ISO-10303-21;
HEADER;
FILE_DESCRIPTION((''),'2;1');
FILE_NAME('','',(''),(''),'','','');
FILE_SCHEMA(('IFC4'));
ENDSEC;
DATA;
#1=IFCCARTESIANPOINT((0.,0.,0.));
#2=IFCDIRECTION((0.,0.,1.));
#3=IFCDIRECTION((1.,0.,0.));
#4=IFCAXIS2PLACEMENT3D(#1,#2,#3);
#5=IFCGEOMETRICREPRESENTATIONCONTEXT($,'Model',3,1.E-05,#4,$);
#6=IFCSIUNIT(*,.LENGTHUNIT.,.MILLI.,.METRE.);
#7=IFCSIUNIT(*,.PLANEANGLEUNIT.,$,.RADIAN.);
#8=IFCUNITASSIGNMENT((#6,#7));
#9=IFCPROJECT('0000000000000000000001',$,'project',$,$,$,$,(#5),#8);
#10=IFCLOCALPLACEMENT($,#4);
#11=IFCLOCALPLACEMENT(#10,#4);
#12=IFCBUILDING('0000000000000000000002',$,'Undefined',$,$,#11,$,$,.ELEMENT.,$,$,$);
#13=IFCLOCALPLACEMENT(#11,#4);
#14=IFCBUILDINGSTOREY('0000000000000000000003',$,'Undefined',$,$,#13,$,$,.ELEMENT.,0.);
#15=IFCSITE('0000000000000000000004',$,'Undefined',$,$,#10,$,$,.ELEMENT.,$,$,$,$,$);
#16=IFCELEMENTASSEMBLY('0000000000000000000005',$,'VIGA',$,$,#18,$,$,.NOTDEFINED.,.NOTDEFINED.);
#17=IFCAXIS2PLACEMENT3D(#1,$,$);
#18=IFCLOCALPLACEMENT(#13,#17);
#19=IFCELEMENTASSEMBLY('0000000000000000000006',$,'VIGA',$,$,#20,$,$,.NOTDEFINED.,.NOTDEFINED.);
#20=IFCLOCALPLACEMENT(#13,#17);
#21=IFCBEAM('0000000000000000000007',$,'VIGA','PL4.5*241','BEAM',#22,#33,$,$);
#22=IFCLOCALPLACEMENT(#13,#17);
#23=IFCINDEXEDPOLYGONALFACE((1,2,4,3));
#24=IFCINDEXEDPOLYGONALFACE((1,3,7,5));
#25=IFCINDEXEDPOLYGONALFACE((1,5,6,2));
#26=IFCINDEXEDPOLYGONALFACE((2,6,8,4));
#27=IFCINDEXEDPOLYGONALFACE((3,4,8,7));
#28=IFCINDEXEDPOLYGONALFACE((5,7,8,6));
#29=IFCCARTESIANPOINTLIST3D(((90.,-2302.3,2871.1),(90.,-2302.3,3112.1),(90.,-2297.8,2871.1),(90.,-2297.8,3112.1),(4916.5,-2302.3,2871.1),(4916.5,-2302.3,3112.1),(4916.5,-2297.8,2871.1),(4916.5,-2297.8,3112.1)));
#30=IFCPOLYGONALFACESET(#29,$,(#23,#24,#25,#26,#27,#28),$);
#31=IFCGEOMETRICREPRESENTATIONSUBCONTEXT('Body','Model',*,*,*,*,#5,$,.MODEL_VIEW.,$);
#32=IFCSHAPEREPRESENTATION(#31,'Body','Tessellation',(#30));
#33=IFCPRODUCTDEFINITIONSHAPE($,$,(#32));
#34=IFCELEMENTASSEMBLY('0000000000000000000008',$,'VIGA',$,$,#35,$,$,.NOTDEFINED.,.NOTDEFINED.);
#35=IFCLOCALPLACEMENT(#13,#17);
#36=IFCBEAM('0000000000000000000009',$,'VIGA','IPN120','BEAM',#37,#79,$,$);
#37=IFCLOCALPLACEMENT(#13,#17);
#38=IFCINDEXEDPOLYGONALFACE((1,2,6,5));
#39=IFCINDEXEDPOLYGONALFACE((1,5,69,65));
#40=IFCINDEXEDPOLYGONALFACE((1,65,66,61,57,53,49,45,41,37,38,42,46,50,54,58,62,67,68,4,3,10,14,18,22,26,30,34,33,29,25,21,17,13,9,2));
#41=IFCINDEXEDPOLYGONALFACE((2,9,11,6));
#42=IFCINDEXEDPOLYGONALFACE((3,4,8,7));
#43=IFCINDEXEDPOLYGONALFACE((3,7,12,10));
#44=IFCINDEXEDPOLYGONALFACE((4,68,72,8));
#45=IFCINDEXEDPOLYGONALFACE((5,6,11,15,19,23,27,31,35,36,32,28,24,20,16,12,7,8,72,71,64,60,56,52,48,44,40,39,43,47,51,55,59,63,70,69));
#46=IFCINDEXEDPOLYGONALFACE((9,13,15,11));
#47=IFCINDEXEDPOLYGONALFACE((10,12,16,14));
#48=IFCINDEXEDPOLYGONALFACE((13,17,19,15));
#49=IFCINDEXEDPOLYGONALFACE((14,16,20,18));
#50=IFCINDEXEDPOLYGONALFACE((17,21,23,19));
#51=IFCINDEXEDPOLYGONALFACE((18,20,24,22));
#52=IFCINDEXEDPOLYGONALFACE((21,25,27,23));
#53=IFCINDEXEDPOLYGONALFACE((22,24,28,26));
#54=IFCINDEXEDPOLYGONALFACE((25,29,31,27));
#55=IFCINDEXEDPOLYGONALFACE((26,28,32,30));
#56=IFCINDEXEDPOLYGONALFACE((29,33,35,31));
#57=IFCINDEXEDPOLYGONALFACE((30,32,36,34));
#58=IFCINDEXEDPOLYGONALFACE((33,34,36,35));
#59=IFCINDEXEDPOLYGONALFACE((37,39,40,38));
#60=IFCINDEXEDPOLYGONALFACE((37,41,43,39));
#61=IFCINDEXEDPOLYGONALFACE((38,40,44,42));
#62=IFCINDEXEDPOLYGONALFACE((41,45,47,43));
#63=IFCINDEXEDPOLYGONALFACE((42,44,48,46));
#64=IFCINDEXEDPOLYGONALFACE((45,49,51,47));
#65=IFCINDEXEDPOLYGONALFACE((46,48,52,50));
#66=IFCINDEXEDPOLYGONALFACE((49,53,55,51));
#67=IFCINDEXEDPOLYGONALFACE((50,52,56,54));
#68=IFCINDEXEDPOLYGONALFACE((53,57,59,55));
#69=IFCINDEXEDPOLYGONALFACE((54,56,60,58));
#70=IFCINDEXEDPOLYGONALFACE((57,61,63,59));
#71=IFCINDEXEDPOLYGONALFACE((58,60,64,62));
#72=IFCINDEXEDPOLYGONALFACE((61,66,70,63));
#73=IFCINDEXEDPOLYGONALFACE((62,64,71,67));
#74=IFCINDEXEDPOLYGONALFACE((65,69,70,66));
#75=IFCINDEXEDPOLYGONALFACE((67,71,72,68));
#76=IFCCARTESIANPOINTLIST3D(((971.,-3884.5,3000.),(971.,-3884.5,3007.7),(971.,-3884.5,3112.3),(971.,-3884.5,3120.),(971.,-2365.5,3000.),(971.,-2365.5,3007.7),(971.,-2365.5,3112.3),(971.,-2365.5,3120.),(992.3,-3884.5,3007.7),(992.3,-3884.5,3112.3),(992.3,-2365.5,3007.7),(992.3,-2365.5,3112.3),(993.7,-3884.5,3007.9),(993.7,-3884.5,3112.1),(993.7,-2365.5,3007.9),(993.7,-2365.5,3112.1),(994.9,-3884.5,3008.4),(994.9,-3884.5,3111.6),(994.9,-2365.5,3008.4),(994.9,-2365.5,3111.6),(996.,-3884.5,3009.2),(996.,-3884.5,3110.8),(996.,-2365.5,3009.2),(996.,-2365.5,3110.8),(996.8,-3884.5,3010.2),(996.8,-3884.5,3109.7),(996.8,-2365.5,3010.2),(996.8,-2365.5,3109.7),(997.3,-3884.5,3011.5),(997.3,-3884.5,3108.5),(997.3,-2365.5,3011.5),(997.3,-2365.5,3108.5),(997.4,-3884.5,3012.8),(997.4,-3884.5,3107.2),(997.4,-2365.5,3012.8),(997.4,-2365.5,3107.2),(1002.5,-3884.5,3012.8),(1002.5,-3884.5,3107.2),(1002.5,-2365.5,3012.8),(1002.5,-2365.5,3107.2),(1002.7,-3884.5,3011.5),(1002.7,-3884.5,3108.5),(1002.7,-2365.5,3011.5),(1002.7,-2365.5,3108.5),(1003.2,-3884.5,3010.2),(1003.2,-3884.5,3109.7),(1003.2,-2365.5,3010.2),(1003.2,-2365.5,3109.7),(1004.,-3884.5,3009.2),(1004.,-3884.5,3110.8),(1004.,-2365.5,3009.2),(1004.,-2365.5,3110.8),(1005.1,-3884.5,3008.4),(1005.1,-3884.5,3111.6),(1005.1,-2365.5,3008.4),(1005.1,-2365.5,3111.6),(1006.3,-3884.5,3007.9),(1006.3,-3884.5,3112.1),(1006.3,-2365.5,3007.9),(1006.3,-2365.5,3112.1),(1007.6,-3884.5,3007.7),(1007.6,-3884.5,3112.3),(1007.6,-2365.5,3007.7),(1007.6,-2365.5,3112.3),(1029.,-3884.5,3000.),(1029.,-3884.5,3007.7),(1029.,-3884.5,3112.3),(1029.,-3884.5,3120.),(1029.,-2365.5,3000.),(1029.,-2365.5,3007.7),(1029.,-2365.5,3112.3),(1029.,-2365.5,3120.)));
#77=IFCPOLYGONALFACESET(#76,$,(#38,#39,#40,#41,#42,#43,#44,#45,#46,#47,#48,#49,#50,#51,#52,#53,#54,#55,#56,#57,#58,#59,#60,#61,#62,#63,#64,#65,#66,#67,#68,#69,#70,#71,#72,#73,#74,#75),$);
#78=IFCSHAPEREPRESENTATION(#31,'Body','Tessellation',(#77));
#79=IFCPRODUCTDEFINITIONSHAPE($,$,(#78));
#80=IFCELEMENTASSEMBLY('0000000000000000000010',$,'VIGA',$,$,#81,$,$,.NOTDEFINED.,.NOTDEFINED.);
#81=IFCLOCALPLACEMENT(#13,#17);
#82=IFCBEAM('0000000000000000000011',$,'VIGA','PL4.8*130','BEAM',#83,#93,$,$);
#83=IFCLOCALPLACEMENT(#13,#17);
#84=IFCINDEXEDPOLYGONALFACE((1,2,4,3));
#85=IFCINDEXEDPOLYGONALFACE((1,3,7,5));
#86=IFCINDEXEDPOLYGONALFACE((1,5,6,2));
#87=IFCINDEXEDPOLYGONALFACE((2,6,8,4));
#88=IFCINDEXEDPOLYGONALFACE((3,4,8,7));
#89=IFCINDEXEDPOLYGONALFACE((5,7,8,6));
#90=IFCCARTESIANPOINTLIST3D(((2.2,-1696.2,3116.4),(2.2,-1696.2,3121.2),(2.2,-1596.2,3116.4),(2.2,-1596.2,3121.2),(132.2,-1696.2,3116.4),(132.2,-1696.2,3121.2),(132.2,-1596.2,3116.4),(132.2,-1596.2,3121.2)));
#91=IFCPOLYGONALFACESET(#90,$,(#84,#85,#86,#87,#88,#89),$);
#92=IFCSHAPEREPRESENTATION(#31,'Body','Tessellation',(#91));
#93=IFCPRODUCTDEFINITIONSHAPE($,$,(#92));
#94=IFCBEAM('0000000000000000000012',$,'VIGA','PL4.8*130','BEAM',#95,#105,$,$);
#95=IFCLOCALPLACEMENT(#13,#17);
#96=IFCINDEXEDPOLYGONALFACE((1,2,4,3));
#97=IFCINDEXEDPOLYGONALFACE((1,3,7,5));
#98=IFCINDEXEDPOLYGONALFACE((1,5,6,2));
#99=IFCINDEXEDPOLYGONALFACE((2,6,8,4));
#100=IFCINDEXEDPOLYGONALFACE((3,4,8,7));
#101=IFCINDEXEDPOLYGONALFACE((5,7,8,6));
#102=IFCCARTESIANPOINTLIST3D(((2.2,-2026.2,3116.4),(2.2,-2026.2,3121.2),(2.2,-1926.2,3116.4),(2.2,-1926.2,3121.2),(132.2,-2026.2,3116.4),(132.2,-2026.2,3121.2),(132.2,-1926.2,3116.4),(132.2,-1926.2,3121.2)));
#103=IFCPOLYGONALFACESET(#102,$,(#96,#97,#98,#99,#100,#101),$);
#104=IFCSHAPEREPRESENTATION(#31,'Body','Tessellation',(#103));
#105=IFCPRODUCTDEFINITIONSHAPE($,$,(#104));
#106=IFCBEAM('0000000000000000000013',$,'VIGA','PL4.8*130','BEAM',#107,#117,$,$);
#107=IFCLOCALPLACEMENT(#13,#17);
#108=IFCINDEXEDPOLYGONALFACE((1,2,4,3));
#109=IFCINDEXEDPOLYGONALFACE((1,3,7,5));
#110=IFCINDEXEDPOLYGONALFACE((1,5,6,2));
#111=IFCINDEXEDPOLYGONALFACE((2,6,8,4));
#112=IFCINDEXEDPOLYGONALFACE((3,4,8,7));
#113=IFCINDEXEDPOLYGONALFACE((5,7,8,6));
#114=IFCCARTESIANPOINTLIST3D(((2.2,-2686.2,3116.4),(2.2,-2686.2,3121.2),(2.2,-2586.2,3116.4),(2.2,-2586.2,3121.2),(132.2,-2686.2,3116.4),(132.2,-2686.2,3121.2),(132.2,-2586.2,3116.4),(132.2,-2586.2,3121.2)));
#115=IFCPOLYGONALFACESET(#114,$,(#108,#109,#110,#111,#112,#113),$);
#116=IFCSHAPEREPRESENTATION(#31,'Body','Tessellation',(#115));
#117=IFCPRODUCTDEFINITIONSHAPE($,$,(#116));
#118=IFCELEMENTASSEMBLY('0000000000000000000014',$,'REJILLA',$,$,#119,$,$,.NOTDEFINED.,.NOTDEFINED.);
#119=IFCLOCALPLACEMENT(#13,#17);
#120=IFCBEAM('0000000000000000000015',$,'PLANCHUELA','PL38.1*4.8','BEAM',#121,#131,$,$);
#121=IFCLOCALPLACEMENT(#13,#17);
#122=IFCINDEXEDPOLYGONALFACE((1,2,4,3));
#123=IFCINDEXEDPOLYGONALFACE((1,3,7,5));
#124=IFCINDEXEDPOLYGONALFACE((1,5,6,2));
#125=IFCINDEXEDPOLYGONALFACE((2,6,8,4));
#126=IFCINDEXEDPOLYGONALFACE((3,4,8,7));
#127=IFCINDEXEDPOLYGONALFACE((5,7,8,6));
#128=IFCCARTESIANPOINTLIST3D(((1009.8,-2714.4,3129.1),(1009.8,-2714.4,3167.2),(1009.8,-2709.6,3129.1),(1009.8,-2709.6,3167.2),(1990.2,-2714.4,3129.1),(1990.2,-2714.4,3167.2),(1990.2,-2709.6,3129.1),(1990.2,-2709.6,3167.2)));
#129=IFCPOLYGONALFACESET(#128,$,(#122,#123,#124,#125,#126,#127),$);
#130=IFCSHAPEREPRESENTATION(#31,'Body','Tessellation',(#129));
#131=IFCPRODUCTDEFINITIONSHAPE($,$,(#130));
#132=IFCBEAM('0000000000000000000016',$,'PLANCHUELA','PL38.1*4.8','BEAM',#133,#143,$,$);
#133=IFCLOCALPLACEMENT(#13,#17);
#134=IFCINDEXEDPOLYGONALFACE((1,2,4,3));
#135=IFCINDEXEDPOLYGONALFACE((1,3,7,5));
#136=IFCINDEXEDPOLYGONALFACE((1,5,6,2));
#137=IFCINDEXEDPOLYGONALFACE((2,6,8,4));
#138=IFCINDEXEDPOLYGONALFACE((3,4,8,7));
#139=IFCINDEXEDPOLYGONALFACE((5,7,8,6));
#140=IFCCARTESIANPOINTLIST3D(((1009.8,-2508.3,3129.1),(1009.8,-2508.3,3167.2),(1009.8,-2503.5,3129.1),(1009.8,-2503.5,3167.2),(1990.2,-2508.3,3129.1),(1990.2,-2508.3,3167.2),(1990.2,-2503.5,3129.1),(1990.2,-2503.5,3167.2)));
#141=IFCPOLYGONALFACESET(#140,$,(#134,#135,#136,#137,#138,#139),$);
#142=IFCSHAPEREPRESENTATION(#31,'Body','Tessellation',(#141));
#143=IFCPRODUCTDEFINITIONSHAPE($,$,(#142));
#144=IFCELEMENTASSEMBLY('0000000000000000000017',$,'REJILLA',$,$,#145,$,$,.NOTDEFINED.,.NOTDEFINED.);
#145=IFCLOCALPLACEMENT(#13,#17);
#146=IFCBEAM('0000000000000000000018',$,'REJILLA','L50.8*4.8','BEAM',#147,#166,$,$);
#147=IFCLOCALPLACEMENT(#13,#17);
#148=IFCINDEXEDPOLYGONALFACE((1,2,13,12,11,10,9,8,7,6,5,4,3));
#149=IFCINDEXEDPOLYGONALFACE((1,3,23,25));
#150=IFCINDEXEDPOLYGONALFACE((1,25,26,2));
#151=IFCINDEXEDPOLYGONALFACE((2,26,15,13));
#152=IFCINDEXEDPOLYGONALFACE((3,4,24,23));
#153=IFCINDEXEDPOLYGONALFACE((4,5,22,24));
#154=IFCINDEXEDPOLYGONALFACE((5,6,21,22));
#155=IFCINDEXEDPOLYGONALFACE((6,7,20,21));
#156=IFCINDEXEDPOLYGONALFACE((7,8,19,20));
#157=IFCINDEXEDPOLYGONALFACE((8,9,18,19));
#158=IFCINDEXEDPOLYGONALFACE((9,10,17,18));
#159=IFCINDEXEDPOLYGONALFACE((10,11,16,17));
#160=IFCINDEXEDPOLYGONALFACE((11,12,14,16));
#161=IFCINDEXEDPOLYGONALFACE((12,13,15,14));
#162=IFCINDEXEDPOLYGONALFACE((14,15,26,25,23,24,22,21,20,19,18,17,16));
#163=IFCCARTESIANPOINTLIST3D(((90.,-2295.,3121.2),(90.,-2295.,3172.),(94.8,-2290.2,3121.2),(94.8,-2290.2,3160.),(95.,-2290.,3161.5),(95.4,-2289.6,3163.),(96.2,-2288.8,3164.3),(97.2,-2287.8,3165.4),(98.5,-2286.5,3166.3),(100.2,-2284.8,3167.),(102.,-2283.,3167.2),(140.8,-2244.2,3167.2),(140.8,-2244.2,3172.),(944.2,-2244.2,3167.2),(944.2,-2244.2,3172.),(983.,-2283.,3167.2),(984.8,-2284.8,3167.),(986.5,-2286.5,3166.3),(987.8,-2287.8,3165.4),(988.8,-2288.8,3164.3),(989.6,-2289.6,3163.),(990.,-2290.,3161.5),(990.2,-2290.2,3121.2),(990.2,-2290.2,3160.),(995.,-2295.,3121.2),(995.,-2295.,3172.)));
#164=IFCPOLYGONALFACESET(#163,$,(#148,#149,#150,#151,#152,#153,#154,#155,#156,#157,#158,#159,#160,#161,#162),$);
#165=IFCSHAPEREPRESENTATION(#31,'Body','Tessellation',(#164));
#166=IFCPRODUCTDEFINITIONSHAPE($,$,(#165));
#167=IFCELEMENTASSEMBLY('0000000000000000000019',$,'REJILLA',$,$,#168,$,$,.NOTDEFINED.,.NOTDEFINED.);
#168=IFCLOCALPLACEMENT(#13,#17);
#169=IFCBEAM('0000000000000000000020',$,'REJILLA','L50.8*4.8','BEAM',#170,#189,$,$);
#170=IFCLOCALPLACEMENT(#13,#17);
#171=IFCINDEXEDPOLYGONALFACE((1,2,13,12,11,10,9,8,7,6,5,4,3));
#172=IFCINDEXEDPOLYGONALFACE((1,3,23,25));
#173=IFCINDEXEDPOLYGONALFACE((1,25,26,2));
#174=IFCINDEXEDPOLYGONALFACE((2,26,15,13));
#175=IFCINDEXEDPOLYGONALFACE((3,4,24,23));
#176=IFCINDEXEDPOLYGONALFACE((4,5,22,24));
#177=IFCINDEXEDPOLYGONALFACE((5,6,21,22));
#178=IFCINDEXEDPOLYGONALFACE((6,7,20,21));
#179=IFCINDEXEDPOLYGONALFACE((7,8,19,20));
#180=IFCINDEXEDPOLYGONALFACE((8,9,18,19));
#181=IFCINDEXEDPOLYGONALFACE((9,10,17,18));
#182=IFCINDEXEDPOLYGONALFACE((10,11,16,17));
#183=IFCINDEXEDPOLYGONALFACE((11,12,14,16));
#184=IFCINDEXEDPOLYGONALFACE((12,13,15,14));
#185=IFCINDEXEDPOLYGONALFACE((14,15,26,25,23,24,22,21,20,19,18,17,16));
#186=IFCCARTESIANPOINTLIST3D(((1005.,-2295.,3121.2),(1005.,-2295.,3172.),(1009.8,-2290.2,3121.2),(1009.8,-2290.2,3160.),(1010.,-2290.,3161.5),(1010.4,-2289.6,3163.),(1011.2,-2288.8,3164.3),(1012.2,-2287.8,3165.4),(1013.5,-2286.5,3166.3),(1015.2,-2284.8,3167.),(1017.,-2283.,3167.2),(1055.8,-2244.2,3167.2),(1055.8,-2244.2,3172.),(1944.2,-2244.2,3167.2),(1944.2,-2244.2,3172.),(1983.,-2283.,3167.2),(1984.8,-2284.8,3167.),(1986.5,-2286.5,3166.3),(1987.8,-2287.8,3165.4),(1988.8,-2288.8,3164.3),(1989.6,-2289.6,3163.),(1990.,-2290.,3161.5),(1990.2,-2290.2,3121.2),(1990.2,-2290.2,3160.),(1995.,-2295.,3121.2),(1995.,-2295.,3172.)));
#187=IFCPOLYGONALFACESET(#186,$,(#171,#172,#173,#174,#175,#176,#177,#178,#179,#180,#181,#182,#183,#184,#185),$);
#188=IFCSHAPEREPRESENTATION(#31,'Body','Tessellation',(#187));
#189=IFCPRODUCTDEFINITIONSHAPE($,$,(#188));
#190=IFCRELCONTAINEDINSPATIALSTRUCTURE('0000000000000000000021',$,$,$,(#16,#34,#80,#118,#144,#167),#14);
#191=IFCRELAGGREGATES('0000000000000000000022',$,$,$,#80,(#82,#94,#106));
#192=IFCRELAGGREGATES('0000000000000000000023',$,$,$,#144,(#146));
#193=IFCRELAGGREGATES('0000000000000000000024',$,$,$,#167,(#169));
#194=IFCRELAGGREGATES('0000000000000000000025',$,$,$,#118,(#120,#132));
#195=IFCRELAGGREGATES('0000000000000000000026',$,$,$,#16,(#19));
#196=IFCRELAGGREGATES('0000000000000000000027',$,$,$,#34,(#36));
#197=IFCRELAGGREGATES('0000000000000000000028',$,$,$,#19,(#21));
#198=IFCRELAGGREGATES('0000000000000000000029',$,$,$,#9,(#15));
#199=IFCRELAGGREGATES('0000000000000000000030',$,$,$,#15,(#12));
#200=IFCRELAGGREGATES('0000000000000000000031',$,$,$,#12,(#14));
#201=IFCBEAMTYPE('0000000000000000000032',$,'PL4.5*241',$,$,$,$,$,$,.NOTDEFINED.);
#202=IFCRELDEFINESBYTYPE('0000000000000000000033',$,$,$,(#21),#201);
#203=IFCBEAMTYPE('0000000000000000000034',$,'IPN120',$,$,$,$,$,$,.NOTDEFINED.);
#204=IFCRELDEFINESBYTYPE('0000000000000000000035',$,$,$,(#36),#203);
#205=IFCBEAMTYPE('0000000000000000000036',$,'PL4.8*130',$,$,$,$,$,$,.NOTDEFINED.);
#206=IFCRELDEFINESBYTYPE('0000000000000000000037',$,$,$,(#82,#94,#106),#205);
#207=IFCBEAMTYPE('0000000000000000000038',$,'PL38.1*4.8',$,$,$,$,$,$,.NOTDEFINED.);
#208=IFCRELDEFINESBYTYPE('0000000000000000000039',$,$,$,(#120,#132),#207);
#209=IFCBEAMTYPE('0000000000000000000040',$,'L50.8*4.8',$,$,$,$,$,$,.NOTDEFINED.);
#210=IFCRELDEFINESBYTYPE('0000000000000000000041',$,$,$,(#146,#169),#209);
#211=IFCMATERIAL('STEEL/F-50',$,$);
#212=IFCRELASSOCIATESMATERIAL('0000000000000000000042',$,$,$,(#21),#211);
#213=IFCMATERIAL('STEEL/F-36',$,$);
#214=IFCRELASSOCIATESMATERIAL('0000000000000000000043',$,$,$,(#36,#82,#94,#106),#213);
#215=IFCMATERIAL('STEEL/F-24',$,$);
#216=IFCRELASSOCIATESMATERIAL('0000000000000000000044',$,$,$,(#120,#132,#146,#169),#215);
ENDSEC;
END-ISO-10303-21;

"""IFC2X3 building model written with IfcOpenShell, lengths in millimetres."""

from ifc_helpers import new_model, si_unit, frame, origin_with_axes, origin_2d_with_axis, place, context, subcontext, project, spatial, rectangle, i_section, l_section, extrude, clip, halfspace, material, type_object, element, aggregate, save


model = new_model("IFC2X3")

# Units and contexts
model_context = context("Model", 3, precision=1e-05, world=origin_with_axes())
body_context = subcontext(model_context, "Body", "Model", "MODEL_VIEW")
ifc_project = project(units=[si_unit("LENGTHUNIT", "METRE", prefix="MILLI"), si_unit("PLANEANGLEUNIT", "RADIAN")], contexts=[model_context])

# Site, building, storey
site_placement = place(None, origin_with_axes())
site = spatial("IfcSite", under=ifc_project, at=site_placement, Name="Undefined", CompositionType="ELEMENT")
building_placement = place(site_placement, origin_with_axes())
building = spatial("IfcBuilding", under=site, at=building_placement, Name="Undefined", CompositionType="ELEMENT")
storey_placement = place(building_placement, origin_with_axes())
storey = spatial("IfcBuildingStorey", under=building, at=storey_placement, Name="Undefined", CompositionType="ELEMENT", Elevation=0.0)

# Element assemblies, beam
assembly_1_placement = place(storey_placement, origin_with_axes())
assembly_1 = element("IfcElementAssembly", 1, at=assembly_1_placement, inside=storey, Name="VIGA", AssemblyPlace="NOTDEFINED", PredefinedType="NOTDEFINED")
assembly_2_placement = place(assembly_1_placement, origin_with_axes())
assembly_2 = element("IfcElementAssembly", 2, at=assembly_2_placement, Name="VIGA", AssemblyPlace="NOTDEFINED", PredefinedType="NOTDEFINED")
ifc_material_1 = material(Name="STEEL/F-50")
beam_type_1 = type_object("IfcBeamType", Name="PL4.5*241", PredefinedType="NOTDEFINED")
beam_1_placement = place(assembly_2_placement, frame((90.0, -2300.0, 2991.6), z_axis=(0.0, 0.0, 1.0), x_axis=(1.0, 0.0, 0.0)))
beam_1 = element("IfcBeam", 3, at=beam_1_placement, type_object=beam_type_1, material=ifc_material_1, Name="VIGA", Description="PL4.5*241", ObjectType="BEAM", context=body_context, shape_type="SweptSolid", body=[
    extrude(rectangle(XDim=4.5, YDim=241.0, at=origin_2d_with_axis()), frame((4826.5, 0.0, 0.0), z_axis=(-1.0, 0.0, 0.0), x_axis=(0.0, -1.0, 0.0)), (0.0, 0.0, 1.0), 4826.5),
])

# Element assembly, beam
assembly_3_placement = place(storey_placement, origin_with_axes())
assembly_3 = element("IfcElementAssembly", 4, at=assembly_3_placement, inside=storey, Name="VIGA", AssemblyPlace="NOTDEFINED", PredefinedType="NOTDEFINED")
ifc_material_2 = material(Name="STEEL/F-36")
beam_type_2 = type_object("IfcBeamType", Name="IPN120", PredefinedType="NOTDEFINED")
beam_2_placement = place(assembly_3_placement, frame((1000.0, -2365.5, 3060.0), z_axis=(0.0, 0.0, 1.0), x_axis=(0.0, -1.0, 0.0)))
beam_2 = element("IfcBeam", 5, at=beam_2_placement, type_object=beam_type_2, material=ifc_material_2, Name="VIGA", Description="IPN120", ObjectType="BEAM", context=body_context, shape_type="SweptSolid", body=[
    extrude(i_section(OverallWidth=58.0, OverallDepth=120.0, WebThickness=5.1, FlangeThickness=7.7, FilletRadius=5.1, at=origin_2d_with_axis()), frame((1519.0, 0.0, 0.0), z_axis=(-1.0, 0.0, 0.0), x_axis=(0.0, -1.0, 0.0)), (0.0, 0.0, 1.0), 1519.0),
])

# Element assemblies, beams
assembly_4_placement = place(storey_placement, origin_with_axes())
assembly_4 = element("IfcElementAssembly", 6, at=assembly_4_placement, inside=storey, Name="VIGA", AssemblyPlace="NOTDEFINED", PredefinedType="NOTDEFINED")
beam_type_3 = type_object("IfcBeamType", Name="PL4.8*130", PredefinedType="NOTDEFINED")
beam_3_placement = place(assembly_4_placement, frame((67.2, -1696.2, 3118.8), z_axis=(1.0, 0.0, 0.0), x_axis=(0.0, 1.0, 0.0)))
beam_3 = element("IfcBeam", 7, at=beam_3_placement, type_object=beam_type_3, material=ifc_material_2, Name="VIGA", Description="PL4.8*130", ObjectType="BEAM", context=body_context, shape_type="SweptSolid", body=[
    extrude(rectangle(XDim=4.8, YDim=130.0, at=origin_2d_with_axis()), frame((100.0, 0.0, 0.0), z_axis=(-1.0, 0.0, 0.0), x_axis=(0.0, -1.0, 0.0)), (0.0, 0.0, 1.0), 100.0),
])
beam_4_placement = place(assembly_4_placement, frame((67.2, -2026.2, 3118.8), z_axis=(1.0, 0.0, 0.0), x_axis=(0.0, 1.0, 0.0)))
beam_4 = element("IfcBeam", 8, at=beam_4_placement, type_object=beam_type_3, material=ifc_material_2, Name="VIGA", Description="PL4.8*130", ObjectType="BEAM", context=body_context, shape_type="SweptSolid", body=[
    extrude(rectangle(XDim=4.8, YDim=130.0, at=origin_2d_with_axis()), frame((100.0, 0.0, 0.0), z_axis=(-1.0, 0.0, 0.0), x_axis=(0.0, -1.0, 0.0)), (0.0, 0.0, 1.0), 100.0),
])
beam_5_placement = place(assembly_4_placement, frame((67.2, -2686.2, 3118.8), z_axis=(1.0, 0.0, 0.0), x_axis=(0.0, 1.0, 0.0)))
beam_5 = element("IfcBeam", 9, at=beam_5_placement, type_object=beam_type_3, material=ifc_material_2, Name="VIGA", Description="PL4.8*130", ObjectType="BEAM", context=body_context, shape_type="SweptSolid", body=[
    extrude(rectangle(XDim=4.8, YDim=130.0, at=origin_2d_with_axis()), frame((100.0, 0.0, 0.0), z_axis=(-1.0, 0.0, 0.0), x_axis=(0.0, -1.0, 0.0)), (0.0, 0.0, 1.0), 100.0),
])
aggregate(assembly_4, [beam_3, beam_4, beam_5])
assembly_5_placement = place(storey_placement, origin_with_axes())
assembly_5 = element("IfcElementAssembly", 10, at=assembly_5_placement, inside=storey, Name="REJILLA", AssemblyPlace="NOTDEFINED", PredefinedType="NOTDEFINED")
ifc_material_3 = material(Name="STEEL/F-24")
beam_type_4 = type_object("IfcBeamType", Name="PL38.1*4.8", PredefinedType="NOTDEFINED")
beam_6_placement = place(assembly_5_placement, frame((1990.2, -2712.0, 3148.1), z_axis=(-0.000041, 0.0, -1.0), x_axis=(-1.0, 0.0, 0.000041)))
beam_6 = element("IfcBeam", 11, at=beam_6_placement, type_object=beam_type_4, material=ifc_material_3, Name="PLANCHUELA", Description="PL38.1*4.8", ObjectType="BEAM", context=body_context, shape_type="SweptSolid", body=[
    extrude(rectangle(XDim=4.8, YDim=38.1, at=origin_2d_with_axis()), frame((980.4, 0.0, 0.0), z_axis=(-1.0, 0.0, 0.0), x_axis=(0.0, -1.0, 0.0)), (0.0, 0.0, 1.0), 980.4),
])
beam_7_placement = place(assembly_5_placement, frame((1990.2, -2505.9, 3148.1), z_axis=(-0.000041, 0.0, -1.0), x_axis=(-1.0, 0.0, 0.000041)))
beam_7 = element("IfcBeam", 12, at=beam_7_placement, type_object=beam_type_4, material=ifc_material_3, Name="PLANCHUELA", Description="PL38.1*4.8", ObjectType="BEAM", context=body_context, shape_type="SweptSolid", body=[
    extrude(rectangle(XDim=4.8, YDim=38.1, at=origin_2d_with_axis()), frame((980.4, 0.0, 0.0), z_axis=(-1.0, 0.0, 0.0), x_axis=(0.0, -1.0, 0.0)), (0.0, 0.0, 1.0), 980.4),
])
assembly_6_placement = place(storey_placement, origin_with_axes())
assembly_6 = element("IfcElementAssembly", 13, at=assembly_6_placement, inside=storey, Name="REJILLA", AssemblyPlace="NOTDEFINED", PredefinedType="NOTDEFINED")
beam_type_5 = type_object("IfcBeamType", Name="L50.8*4.8", PredefinedType="NOTDEFINED")
beam_8_placement = place(assembly_6_placement, frame((90.0, -2269.6, 3146.6), z_axis=(0.0, 0.0, -1.0), x_axis=(1.0, 0.0, 0.0)))
beam_8 = element("IfcBeam", 14, at=beam_8_placement, type_object=beam_type_5, material=ifc_material_3, Name="REJILLA", Description="L50.8*4.8", ObjectType="BEAM", context=body_context, shape_type="Clipping", body=[
    clip(clip(extrude(l_section(Depth=50.8, Width=50.8, Thickness=4.8, FilletRadius=7.2, at=origin_2d_with_axis()), frame((930.9, 0.0, 0.0), z_axis=(-1.0, 0.0, 0.0), x_axis=(0.0, -1.0, 0.0)), (0.0, 0.0, 1.0), 956.8), halfspace(frame((854.2, -25.4, 0.0), z_axis=(-0.707107, 0.707107, 0.0), x_axis=(0.0, 0.0, -1.0)), True)), halfspace(frame((50.8, -25.4, 0.0), z_axis=(-0.707107, -0.707107, 0.0), x_axis=(0.0, 0.0, -1.0)), False)),
])
aggregate(assembly_6, [beam_8])
assembly_7_placement = place(storey_placement, origin_with_axes())
assembly_7 = element("IfcElementAssembly", 15, at=assembly_7_placement, inside=storey, Name="REJILLA", AssemblyPlace="NOTDEFINED", PredefinedType="NOTDEFINED")
beam_9_placement = place(assembly_7_placement, frame((1005.0, -2269.6, 3146.6), z_axis=(0.0, 0.0, -1.0), x_axis=(1.0, 0.0, 0.0)))
beam_9 = element("IfcBeam", 16, at=beam_9_placement, type_object=beam_type_5, material=ifc_material_3, Name="REJILLA", Description="L50.8*4.8", ObjectType="BEAM", context=body_context, shape_type="Clipping", body=[
    clip(clip(extrude(l_section(Depth=50.8, Width=50.8, Thickness=4.8, FilletRadius=7.2, at=origin_2d_with_axis()), frame((1015.9, 0.0, 0.0), z_axis=(-1.0, 0.0, 0.0), x_axis=(0.0, -1.0, 0.0)), (0.0, 0.0, 1.0), 1041.8), halfspace(frame((939.2, -25.4, 0.0), z_axis=(-0.707107, 0.707107, 0.0), x_axis=(0.0, 0.0, -1.0)), True)), halfspace(frame((50.8, -25.4, 0.0), z_axis=(-0.707107, -0.707107, 0.0), x_axis=(0.0, 0.0, -1.0)), False)),
])
aggregate(assembly_7, [beam_9])

aggregate(assembly_5, [beam_6, beam_7])

aggregate(assembly_1, [assembly_2])

aggregate(assembly_3, [beam_2])

aggregate(assembly_2, [beam_1])

save(model, "model.ifc")
